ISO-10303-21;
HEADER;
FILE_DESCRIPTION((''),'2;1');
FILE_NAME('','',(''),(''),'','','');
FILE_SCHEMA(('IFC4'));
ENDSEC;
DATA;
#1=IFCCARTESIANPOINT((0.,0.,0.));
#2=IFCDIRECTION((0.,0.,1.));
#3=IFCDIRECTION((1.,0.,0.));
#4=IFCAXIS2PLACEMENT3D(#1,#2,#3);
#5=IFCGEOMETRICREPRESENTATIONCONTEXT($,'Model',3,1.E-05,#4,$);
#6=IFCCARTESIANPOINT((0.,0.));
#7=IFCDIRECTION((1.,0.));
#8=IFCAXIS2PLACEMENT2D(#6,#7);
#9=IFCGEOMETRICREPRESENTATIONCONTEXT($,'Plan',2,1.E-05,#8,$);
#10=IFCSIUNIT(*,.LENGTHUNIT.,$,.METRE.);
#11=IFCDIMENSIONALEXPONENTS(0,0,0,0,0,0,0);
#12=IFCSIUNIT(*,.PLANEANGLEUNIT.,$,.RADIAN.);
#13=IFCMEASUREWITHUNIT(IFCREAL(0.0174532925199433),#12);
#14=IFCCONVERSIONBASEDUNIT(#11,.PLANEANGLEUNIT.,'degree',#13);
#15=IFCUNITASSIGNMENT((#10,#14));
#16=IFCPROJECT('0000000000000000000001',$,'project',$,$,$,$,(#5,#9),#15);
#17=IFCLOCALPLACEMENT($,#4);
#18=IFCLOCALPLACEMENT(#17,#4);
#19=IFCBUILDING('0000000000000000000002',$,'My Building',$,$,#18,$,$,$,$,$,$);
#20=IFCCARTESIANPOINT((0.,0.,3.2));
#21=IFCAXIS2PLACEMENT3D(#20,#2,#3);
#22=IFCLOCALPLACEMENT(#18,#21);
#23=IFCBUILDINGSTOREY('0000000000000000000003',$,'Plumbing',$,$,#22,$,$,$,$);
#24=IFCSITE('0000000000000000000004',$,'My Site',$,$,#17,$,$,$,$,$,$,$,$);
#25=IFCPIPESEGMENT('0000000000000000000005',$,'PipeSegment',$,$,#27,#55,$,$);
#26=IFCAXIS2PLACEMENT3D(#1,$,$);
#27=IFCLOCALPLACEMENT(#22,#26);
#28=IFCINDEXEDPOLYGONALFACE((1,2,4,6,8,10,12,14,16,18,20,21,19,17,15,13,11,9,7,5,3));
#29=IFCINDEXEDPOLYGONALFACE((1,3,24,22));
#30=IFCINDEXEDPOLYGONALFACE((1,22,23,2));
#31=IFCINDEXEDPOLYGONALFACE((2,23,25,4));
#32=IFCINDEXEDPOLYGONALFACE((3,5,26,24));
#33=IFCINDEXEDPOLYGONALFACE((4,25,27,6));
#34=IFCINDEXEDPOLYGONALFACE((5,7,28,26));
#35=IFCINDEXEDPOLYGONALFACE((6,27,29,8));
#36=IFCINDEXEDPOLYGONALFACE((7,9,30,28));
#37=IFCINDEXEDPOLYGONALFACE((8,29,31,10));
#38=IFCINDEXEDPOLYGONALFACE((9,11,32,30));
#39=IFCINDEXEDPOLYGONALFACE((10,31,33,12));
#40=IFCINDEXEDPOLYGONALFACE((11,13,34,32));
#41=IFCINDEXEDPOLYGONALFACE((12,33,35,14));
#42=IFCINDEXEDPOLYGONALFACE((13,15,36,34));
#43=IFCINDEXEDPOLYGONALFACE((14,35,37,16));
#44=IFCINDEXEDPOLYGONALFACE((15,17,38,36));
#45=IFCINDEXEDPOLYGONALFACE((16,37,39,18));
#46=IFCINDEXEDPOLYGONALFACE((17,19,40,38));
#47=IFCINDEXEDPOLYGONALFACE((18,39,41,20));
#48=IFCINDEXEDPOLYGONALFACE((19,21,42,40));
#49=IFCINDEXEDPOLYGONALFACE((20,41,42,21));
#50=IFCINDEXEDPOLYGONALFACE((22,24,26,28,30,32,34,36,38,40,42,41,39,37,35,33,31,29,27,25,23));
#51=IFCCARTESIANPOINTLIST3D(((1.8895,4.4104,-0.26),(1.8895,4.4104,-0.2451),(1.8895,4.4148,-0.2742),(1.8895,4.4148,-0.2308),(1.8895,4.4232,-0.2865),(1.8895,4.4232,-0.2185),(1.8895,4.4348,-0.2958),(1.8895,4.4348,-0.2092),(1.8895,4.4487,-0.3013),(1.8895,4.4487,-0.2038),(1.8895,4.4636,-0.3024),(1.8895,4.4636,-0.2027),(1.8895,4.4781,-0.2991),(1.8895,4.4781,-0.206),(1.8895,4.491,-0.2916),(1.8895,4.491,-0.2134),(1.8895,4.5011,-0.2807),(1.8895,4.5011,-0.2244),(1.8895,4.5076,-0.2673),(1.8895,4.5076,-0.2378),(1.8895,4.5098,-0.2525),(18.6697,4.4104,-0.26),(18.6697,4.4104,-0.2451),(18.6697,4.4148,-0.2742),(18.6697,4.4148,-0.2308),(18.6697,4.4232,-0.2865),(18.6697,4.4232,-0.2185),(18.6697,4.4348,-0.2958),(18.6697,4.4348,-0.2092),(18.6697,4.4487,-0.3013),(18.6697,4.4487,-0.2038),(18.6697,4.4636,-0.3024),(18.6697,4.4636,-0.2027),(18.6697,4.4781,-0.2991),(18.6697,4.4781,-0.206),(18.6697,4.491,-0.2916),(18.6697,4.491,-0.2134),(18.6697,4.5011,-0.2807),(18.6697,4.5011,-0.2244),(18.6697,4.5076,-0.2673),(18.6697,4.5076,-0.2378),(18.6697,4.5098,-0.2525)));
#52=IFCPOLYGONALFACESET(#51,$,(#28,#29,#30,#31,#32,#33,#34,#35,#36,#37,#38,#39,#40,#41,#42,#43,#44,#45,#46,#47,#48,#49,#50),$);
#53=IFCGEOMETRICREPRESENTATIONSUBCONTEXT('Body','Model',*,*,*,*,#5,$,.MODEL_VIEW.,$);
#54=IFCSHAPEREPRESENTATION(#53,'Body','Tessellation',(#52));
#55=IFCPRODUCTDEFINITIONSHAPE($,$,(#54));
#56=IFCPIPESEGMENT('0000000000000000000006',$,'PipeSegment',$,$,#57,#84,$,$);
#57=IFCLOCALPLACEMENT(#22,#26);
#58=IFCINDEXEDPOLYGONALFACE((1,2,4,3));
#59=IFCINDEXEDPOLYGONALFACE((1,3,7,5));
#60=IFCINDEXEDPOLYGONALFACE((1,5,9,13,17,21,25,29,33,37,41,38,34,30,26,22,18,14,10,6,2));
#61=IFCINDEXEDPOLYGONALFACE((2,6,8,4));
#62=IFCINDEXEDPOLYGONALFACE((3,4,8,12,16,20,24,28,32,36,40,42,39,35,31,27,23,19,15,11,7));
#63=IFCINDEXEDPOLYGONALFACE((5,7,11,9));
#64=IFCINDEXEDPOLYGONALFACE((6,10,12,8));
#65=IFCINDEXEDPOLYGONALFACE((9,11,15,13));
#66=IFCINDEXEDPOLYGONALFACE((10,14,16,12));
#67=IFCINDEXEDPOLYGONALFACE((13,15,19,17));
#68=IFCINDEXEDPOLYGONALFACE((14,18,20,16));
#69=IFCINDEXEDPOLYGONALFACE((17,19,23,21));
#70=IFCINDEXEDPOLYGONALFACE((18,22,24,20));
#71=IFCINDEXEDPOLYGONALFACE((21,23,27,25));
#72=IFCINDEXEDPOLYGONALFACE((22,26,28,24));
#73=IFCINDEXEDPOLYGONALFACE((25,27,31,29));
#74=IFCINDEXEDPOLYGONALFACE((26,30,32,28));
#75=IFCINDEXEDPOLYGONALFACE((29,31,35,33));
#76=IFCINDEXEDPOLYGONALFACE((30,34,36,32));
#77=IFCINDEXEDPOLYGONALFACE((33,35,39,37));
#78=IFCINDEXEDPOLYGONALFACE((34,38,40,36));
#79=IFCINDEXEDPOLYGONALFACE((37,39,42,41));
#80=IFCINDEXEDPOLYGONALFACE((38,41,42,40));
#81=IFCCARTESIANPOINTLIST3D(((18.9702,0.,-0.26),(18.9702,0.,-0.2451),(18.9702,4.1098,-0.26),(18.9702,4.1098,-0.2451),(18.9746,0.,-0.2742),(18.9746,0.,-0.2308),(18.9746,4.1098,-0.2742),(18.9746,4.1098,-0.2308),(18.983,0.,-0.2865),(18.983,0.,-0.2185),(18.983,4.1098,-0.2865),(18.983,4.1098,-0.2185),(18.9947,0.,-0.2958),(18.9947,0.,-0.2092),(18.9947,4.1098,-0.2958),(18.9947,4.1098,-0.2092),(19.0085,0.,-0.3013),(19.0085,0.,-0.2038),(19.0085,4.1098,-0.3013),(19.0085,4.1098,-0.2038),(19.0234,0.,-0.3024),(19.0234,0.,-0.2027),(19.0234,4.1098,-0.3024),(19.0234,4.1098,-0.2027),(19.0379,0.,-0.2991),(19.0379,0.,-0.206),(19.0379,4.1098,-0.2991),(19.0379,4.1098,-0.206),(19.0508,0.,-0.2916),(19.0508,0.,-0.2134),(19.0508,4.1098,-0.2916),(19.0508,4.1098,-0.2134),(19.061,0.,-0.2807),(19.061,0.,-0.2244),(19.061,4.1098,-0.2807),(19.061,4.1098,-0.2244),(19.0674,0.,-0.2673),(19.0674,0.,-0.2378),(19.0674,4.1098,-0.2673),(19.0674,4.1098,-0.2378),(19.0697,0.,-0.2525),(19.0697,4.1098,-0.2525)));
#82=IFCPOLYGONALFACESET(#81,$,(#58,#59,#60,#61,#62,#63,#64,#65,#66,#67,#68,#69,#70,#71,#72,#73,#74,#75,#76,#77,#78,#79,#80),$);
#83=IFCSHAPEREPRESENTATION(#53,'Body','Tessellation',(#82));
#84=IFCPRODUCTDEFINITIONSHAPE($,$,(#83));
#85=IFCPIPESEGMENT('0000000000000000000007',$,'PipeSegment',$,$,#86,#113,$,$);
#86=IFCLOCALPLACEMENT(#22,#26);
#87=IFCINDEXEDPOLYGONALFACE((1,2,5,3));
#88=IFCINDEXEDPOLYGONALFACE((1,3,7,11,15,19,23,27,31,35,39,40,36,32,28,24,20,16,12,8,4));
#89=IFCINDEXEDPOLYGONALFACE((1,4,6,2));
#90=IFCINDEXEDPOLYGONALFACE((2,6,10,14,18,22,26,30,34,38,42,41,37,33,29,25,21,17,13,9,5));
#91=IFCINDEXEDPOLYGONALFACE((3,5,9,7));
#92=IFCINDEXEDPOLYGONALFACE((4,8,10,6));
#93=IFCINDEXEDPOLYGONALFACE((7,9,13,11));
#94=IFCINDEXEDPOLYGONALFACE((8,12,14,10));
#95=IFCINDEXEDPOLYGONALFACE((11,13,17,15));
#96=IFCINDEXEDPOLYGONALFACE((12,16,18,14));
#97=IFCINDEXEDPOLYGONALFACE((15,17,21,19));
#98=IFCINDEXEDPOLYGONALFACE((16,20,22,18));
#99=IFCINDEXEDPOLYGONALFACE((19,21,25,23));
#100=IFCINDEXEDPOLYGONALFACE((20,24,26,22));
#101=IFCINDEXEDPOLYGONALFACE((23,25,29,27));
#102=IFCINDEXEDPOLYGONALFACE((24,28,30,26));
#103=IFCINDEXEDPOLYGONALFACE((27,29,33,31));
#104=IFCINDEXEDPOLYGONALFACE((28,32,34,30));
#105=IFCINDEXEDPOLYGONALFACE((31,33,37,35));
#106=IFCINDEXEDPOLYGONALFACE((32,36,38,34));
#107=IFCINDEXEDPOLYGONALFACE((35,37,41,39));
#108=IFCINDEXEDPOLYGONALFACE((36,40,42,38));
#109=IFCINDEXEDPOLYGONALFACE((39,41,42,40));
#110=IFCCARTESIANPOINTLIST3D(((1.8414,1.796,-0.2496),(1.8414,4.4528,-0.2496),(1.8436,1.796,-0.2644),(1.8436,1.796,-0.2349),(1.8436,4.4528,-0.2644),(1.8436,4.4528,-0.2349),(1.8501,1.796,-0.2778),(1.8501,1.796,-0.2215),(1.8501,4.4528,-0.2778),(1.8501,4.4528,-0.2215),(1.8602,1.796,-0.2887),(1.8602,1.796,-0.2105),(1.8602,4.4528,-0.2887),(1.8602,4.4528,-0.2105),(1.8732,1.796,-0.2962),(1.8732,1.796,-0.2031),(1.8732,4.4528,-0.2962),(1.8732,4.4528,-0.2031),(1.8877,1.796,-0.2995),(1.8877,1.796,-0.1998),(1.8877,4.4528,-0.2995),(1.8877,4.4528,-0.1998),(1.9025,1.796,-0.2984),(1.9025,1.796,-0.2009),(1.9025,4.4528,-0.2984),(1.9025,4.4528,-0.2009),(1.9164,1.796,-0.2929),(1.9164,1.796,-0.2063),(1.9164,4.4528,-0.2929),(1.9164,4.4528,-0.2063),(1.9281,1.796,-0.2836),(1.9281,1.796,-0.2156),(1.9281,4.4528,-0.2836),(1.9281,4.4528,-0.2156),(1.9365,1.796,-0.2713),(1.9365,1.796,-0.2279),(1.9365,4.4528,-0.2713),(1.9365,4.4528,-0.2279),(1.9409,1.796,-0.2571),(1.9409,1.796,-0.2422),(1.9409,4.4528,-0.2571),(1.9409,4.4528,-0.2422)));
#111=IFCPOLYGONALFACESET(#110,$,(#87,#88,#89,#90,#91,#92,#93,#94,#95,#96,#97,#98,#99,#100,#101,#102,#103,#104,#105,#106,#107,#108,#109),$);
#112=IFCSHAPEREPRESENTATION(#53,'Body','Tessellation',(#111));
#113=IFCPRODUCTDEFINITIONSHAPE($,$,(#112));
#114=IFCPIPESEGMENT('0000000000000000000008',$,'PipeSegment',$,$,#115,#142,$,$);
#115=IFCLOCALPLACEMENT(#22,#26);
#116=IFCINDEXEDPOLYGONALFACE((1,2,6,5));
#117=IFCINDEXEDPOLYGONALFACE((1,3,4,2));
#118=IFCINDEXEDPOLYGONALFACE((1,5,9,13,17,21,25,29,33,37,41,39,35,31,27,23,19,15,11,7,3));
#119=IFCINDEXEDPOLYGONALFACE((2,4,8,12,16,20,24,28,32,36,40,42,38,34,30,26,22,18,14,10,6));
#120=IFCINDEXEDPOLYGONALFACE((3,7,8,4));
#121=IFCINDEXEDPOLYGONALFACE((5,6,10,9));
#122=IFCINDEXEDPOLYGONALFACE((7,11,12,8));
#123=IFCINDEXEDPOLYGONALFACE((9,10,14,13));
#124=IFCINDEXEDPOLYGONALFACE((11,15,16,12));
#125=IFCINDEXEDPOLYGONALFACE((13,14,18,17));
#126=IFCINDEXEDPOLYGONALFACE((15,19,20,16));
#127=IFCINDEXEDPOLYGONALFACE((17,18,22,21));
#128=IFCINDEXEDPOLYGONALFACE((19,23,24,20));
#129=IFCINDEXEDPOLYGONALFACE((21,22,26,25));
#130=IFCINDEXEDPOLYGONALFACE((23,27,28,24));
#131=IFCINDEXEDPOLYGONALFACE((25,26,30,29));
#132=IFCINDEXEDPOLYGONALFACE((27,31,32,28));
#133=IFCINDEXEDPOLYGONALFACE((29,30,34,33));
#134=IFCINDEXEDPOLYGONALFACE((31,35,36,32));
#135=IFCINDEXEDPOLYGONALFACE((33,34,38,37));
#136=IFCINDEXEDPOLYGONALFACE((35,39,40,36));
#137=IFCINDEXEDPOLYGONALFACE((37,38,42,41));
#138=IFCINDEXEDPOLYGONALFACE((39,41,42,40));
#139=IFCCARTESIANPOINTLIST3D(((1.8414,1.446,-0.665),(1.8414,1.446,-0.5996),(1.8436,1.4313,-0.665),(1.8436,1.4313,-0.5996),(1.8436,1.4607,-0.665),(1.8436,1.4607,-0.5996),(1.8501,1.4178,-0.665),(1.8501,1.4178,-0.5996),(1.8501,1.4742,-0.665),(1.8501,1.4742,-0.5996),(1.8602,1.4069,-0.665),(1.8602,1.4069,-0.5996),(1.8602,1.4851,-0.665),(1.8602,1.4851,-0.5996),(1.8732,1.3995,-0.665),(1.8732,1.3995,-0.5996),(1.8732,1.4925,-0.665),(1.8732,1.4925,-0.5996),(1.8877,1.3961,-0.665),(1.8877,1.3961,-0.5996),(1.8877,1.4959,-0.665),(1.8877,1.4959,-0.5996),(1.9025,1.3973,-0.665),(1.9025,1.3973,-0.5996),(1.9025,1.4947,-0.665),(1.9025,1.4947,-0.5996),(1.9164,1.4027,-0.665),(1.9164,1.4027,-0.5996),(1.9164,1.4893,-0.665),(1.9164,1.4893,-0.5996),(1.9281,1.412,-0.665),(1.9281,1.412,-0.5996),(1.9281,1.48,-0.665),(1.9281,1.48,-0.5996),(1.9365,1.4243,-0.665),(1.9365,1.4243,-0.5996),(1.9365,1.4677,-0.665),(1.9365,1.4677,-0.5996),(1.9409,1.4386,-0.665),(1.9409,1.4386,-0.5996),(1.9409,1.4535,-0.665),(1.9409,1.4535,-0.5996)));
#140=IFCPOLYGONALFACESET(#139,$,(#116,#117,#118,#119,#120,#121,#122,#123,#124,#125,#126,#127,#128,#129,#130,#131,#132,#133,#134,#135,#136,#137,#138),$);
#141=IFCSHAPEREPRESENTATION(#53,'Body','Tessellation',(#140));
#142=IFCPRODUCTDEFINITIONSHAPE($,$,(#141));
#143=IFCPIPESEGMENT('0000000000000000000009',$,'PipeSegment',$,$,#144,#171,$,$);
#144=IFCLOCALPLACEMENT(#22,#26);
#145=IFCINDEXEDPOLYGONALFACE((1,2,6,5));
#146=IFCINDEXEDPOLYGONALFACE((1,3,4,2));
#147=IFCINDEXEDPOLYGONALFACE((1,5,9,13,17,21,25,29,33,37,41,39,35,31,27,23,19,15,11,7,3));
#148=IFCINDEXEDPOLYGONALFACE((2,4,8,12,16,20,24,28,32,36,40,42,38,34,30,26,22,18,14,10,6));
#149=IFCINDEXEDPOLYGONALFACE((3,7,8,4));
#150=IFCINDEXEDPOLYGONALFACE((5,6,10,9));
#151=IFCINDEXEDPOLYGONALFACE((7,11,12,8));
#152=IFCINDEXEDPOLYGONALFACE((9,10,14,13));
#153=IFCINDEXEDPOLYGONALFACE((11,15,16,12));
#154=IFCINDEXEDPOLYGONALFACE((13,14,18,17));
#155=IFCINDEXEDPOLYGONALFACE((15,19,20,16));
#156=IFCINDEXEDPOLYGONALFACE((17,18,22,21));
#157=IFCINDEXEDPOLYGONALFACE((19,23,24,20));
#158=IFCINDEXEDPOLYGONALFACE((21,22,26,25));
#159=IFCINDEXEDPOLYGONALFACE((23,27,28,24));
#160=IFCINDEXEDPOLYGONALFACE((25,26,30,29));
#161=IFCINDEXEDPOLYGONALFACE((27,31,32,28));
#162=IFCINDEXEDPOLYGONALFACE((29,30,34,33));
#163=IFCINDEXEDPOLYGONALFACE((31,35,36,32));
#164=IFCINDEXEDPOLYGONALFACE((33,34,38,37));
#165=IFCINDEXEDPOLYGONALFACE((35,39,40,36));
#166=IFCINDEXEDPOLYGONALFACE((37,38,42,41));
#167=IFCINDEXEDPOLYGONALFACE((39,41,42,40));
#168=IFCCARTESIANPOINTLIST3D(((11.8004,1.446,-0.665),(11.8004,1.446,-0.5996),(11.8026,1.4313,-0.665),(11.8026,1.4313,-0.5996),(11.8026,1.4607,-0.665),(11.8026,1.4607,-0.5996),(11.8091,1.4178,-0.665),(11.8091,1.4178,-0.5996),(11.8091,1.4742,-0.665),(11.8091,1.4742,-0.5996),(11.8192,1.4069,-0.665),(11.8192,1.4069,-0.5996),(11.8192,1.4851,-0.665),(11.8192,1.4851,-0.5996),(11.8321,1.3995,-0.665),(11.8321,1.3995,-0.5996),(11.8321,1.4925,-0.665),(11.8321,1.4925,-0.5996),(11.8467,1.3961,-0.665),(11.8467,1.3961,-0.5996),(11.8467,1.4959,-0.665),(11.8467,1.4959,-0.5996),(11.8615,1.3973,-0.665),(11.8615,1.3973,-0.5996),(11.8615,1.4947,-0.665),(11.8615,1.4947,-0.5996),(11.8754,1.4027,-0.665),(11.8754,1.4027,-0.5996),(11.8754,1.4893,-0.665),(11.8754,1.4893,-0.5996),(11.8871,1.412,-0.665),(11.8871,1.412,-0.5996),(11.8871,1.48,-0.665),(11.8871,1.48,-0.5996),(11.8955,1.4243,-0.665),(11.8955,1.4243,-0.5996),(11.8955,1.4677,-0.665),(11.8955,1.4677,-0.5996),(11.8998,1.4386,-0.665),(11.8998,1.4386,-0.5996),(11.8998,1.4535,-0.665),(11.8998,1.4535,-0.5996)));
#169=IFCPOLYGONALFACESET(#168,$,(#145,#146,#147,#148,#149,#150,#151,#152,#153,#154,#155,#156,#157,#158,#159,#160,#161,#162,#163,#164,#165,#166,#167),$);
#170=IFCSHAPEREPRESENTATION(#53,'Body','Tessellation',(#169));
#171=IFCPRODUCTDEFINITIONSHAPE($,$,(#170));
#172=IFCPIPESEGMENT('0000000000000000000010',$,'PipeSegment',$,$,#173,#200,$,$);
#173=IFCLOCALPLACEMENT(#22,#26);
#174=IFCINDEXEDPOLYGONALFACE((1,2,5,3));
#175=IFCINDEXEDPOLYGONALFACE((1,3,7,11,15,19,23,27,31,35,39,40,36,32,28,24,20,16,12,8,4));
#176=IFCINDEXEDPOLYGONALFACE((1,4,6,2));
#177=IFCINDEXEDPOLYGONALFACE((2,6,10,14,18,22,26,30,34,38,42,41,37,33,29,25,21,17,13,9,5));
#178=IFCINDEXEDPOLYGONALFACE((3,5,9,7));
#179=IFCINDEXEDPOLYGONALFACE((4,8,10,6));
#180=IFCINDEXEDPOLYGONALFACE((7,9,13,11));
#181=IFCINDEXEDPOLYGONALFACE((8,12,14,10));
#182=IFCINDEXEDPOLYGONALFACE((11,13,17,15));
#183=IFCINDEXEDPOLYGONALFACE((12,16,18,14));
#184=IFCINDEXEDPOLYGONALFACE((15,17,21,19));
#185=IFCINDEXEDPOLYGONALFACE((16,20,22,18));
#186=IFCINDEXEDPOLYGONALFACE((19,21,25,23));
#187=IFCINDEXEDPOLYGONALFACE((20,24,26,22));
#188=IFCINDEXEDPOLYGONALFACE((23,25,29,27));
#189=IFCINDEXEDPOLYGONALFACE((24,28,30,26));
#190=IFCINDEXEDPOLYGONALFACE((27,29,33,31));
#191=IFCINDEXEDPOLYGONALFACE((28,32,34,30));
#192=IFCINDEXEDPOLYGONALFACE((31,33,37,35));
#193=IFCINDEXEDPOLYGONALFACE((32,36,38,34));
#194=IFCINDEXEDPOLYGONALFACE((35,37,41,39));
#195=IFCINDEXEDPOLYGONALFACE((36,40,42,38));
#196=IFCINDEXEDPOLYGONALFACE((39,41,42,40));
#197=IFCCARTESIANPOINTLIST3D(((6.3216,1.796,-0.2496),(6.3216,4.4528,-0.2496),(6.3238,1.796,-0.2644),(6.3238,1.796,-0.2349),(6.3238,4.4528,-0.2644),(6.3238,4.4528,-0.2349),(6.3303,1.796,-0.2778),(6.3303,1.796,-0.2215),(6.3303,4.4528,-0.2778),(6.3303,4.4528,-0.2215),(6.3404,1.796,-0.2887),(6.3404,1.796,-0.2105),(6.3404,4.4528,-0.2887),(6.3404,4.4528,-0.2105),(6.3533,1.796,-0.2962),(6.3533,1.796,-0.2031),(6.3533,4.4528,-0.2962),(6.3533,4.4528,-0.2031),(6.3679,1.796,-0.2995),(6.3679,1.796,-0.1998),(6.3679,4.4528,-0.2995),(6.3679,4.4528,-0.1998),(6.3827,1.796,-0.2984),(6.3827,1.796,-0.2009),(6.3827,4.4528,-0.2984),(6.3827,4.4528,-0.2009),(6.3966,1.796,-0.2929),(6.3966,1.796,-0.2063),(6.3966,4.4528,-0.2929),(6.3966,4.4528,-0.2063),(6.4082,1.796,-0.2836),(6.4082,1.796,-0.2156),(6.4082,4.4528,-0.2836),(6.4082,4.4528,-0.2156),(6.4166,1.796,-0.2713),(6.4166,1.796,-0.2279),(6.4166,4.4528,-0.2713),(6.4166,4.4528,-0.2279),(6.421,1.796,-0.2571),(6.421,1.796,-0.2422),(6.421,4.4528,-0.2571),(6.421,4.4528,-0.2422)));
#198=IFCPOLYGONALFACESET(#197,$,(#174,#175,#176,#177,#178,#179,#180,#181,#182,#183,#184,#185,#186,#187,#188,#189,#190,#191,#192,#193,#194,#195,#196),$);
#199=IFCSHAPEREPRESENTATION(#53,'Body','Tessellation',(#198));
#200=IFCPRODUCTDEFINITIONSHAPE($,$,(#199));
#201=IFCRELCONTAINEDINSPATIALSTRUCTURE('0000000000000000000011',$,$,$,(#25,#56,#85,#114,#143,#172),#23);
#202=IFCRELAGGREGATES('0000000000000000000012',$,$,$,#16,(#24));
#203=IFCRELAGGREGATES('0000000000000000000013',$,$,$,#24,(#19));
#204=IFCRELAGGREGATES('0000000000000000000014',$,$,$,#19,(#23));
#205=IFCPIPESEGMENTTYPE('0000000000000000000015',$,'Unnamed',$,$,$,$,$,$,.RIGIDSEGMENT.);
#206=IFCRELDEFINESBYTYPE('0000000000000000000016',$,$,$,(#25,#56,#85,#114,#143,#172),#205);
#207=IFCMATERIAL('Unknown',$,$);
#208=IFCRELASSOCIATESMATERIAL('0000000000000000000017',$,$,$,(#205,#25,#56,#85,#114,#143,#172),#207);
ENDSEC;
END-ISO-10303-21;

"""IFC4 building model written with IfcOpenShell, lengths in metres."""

from ifc_helpers import new_model, entity, si_unit, converted_unit, frame, origin_with_axes, origin_2d_with_axis, place, context, subcontext, project, spatial, circle, extrude, material, material_profile, profile_set, profile_usage, type_object, element, save


model = new_model("IFC4")

# Units and contexts
model_context = context("Model", 3, precision=1e-05, world=origin_with_axes())
plan_context = context("Plan", 2, precision=1e-05, world=origin_2d_with_axis())
body_context = subcontext(model_context, "Body", "Model", "MODEL_VIEW")
ifc_project = project(units=[si_unit("LENGTHUNIT", "METRE"), converted_unit("PLANEANGLEUNIT", "degree", entity("IfcReal", 0.0174532925199433), si_unit("PLANEANGLEUNIT", "RADIAN"), dimensions=[0, 0, 0, 0, 0, 0, 0])], contexts=[model_context, plan_context])

# Site, building, storey
site_placement = place(None, origin_with_axes())
site = spatial("IfcSite", under=ifc_project, at=site_placement, Name="My Site")
building_placement = place(site_placement, origin_with_axes())
building = spatial("IfcBuilding", under=site, at=building_placement, Name="My Building")
storey_placement = place(building_placement, frame((0.0, 0.0, 3.2), z_axis=(0.0, 0.0, 1.0), x_axis=(1.0, 0.0, 0.0)))
storey = spatial("IfcBuildingStorey", under=building, at=storey_placement, Name="Plumbing")

# Pipe segments
ifc_material = material(Name="Unknown")
ifc_material_profile = material_profile(ifc_material, circle(Radius=0.05))
ifc_profile_set = profile_set([ifc_material_profile])
ifc_profile_usage_1 = profile_usage(ifc_profile_set, cardinal=5)
pipe_segment_type = type_object("IfcPipeSegmentType", Name="Unnamed", PredefinedType="RIGIDSEGMENT", material=ifc_profile_set)
pipe_segment_1_placement = place(storey_placement, frame((1.8895, 4.4598, -0.2525), z_axis=(1.0, 0.0, 0.0), x_axis=(0.0, 1.0, 0.0)))
element("IfcPipeSegment", 1, at=pipe_segment_1_placement, inside=storey, type_object=pipe_segment_type, material=ifc_profile_usage_1, Name="PipeSegment", context=body_context, shape_type="SweptSolid", body=[
    extrude(circle(Radius=0.05), origin_with_axes(), (0.0, 0.0, 1.0), 16.7801),
])
ifc_profile_usage_2 = profile_usage(ifc_profile_set, cardinal=5)
pipe_segment_2_placement = place(storey_placement, frame((19.0197, 4.1098, -0.2525), z_axis=(0.0, -1.0, 0.0), x_axis=(1.0, 0.0, 0.0)))
element("IfcPipeSegment", 2, at=pipe_segment_2_placement, inside=storey, type_object=pipe_segment_type, material=ifc_profile_usage_2, Name="PipeSegment", context=body_context, shape_type="SweptSolid", body=[
    extrude(circle(Radius=0.05), origin_with_axes(), (0.0, 0.0, 1.0), 4.1098),
])
ifc_profile_usage_3 = profile_usage(ifc_profile_set, cardinal=5)
pipe_segment_3_placement = place(storey_placement, frame((1.8914, 1.796, -0.2496), z_axis=(0.0, 1.0, 0.0), x_axis=(-1.0, 0.0, 0.0)))
element("IfcPipeSegment", 3, at=pipe_segment_3_placement, inside=storey, type_object=pipe_segment_type, material=ifc_profile_usage_3, Name="PipeSegment", context=body_context, shape_type="SweptSolid", body=[
    extrude(circle(Radius=0.05), origin_with_axes(), (0.0, 0.0, 1.0), 2.6568),
])
ifc_profile_usage_4 = profile_usage(ifc_profile_set, cardinal=5)
pipe_segment_4_placement = place(storey_placement, frame((1.8914, 1.446, -0.5996), z_axis=(0.0, 0.0, -1.0), x_axis=(-1.0, 0.0, 0.0)))
element("IfcPipeSegment", 4, at=pipe_segment_4_placement, inside=storey, type_object=pipe_segment_type, material=ifc_profile_usage_4, Name="PipeSegment", context=body_context, shape_type="SweptSolid", body=[
    extrude(circle(Radius=0.05), origin_with_axes(), (0.0, 0.0, 1.0), 0.0654),
])
ifc_profile_usage_5 = profile_usage(ifc_profile_set, cardinal=5)
pipe_segment_5_placement = place(storey_placement, frame((11.8504, 1.446, -0.5996), z_axis=(0.0, 0.0, -1.0), x_axis=(-1.0, 0.0, 0.0)))
element("IfcPipeSegment", 5, at=pipe_segment_5_placement, inside=storey, type_object=pipe_segment_type, material=ifc_profile_usage_5, Name="PipeSegment", context=body_context, shape_type="SweptSolid", body=[
    extrude(circle(Radius=0.05), origin_with_axes(), (0.0, 0.0, 1.0), 0.0654),
])
ifc_profile_usage_6 = profile_usage(ifc_profile_set, cardinal=5)
pipe_segment_6_placement = place(storey_placement, frame((6.3716, 1.796, -0.2496), z_axis=(0.0, 1.0, 0.0), x_axis=(-1.0, 0.0, 0.0)))
element("IfcPipeSegment", 6, at=pipe_segment_6_placement, inside=storey, type_object=pipe_segment_type, material=ifc_profile_usage_6, Name="PipeSegment", context=body_context, shape_type="SweptSolid", body=[
    extrude(circle(Radius=0.05), origin_with_axes(), (0.0, 0.0, 1.0), 2.6568),
])

save(model, "model.ifc")
